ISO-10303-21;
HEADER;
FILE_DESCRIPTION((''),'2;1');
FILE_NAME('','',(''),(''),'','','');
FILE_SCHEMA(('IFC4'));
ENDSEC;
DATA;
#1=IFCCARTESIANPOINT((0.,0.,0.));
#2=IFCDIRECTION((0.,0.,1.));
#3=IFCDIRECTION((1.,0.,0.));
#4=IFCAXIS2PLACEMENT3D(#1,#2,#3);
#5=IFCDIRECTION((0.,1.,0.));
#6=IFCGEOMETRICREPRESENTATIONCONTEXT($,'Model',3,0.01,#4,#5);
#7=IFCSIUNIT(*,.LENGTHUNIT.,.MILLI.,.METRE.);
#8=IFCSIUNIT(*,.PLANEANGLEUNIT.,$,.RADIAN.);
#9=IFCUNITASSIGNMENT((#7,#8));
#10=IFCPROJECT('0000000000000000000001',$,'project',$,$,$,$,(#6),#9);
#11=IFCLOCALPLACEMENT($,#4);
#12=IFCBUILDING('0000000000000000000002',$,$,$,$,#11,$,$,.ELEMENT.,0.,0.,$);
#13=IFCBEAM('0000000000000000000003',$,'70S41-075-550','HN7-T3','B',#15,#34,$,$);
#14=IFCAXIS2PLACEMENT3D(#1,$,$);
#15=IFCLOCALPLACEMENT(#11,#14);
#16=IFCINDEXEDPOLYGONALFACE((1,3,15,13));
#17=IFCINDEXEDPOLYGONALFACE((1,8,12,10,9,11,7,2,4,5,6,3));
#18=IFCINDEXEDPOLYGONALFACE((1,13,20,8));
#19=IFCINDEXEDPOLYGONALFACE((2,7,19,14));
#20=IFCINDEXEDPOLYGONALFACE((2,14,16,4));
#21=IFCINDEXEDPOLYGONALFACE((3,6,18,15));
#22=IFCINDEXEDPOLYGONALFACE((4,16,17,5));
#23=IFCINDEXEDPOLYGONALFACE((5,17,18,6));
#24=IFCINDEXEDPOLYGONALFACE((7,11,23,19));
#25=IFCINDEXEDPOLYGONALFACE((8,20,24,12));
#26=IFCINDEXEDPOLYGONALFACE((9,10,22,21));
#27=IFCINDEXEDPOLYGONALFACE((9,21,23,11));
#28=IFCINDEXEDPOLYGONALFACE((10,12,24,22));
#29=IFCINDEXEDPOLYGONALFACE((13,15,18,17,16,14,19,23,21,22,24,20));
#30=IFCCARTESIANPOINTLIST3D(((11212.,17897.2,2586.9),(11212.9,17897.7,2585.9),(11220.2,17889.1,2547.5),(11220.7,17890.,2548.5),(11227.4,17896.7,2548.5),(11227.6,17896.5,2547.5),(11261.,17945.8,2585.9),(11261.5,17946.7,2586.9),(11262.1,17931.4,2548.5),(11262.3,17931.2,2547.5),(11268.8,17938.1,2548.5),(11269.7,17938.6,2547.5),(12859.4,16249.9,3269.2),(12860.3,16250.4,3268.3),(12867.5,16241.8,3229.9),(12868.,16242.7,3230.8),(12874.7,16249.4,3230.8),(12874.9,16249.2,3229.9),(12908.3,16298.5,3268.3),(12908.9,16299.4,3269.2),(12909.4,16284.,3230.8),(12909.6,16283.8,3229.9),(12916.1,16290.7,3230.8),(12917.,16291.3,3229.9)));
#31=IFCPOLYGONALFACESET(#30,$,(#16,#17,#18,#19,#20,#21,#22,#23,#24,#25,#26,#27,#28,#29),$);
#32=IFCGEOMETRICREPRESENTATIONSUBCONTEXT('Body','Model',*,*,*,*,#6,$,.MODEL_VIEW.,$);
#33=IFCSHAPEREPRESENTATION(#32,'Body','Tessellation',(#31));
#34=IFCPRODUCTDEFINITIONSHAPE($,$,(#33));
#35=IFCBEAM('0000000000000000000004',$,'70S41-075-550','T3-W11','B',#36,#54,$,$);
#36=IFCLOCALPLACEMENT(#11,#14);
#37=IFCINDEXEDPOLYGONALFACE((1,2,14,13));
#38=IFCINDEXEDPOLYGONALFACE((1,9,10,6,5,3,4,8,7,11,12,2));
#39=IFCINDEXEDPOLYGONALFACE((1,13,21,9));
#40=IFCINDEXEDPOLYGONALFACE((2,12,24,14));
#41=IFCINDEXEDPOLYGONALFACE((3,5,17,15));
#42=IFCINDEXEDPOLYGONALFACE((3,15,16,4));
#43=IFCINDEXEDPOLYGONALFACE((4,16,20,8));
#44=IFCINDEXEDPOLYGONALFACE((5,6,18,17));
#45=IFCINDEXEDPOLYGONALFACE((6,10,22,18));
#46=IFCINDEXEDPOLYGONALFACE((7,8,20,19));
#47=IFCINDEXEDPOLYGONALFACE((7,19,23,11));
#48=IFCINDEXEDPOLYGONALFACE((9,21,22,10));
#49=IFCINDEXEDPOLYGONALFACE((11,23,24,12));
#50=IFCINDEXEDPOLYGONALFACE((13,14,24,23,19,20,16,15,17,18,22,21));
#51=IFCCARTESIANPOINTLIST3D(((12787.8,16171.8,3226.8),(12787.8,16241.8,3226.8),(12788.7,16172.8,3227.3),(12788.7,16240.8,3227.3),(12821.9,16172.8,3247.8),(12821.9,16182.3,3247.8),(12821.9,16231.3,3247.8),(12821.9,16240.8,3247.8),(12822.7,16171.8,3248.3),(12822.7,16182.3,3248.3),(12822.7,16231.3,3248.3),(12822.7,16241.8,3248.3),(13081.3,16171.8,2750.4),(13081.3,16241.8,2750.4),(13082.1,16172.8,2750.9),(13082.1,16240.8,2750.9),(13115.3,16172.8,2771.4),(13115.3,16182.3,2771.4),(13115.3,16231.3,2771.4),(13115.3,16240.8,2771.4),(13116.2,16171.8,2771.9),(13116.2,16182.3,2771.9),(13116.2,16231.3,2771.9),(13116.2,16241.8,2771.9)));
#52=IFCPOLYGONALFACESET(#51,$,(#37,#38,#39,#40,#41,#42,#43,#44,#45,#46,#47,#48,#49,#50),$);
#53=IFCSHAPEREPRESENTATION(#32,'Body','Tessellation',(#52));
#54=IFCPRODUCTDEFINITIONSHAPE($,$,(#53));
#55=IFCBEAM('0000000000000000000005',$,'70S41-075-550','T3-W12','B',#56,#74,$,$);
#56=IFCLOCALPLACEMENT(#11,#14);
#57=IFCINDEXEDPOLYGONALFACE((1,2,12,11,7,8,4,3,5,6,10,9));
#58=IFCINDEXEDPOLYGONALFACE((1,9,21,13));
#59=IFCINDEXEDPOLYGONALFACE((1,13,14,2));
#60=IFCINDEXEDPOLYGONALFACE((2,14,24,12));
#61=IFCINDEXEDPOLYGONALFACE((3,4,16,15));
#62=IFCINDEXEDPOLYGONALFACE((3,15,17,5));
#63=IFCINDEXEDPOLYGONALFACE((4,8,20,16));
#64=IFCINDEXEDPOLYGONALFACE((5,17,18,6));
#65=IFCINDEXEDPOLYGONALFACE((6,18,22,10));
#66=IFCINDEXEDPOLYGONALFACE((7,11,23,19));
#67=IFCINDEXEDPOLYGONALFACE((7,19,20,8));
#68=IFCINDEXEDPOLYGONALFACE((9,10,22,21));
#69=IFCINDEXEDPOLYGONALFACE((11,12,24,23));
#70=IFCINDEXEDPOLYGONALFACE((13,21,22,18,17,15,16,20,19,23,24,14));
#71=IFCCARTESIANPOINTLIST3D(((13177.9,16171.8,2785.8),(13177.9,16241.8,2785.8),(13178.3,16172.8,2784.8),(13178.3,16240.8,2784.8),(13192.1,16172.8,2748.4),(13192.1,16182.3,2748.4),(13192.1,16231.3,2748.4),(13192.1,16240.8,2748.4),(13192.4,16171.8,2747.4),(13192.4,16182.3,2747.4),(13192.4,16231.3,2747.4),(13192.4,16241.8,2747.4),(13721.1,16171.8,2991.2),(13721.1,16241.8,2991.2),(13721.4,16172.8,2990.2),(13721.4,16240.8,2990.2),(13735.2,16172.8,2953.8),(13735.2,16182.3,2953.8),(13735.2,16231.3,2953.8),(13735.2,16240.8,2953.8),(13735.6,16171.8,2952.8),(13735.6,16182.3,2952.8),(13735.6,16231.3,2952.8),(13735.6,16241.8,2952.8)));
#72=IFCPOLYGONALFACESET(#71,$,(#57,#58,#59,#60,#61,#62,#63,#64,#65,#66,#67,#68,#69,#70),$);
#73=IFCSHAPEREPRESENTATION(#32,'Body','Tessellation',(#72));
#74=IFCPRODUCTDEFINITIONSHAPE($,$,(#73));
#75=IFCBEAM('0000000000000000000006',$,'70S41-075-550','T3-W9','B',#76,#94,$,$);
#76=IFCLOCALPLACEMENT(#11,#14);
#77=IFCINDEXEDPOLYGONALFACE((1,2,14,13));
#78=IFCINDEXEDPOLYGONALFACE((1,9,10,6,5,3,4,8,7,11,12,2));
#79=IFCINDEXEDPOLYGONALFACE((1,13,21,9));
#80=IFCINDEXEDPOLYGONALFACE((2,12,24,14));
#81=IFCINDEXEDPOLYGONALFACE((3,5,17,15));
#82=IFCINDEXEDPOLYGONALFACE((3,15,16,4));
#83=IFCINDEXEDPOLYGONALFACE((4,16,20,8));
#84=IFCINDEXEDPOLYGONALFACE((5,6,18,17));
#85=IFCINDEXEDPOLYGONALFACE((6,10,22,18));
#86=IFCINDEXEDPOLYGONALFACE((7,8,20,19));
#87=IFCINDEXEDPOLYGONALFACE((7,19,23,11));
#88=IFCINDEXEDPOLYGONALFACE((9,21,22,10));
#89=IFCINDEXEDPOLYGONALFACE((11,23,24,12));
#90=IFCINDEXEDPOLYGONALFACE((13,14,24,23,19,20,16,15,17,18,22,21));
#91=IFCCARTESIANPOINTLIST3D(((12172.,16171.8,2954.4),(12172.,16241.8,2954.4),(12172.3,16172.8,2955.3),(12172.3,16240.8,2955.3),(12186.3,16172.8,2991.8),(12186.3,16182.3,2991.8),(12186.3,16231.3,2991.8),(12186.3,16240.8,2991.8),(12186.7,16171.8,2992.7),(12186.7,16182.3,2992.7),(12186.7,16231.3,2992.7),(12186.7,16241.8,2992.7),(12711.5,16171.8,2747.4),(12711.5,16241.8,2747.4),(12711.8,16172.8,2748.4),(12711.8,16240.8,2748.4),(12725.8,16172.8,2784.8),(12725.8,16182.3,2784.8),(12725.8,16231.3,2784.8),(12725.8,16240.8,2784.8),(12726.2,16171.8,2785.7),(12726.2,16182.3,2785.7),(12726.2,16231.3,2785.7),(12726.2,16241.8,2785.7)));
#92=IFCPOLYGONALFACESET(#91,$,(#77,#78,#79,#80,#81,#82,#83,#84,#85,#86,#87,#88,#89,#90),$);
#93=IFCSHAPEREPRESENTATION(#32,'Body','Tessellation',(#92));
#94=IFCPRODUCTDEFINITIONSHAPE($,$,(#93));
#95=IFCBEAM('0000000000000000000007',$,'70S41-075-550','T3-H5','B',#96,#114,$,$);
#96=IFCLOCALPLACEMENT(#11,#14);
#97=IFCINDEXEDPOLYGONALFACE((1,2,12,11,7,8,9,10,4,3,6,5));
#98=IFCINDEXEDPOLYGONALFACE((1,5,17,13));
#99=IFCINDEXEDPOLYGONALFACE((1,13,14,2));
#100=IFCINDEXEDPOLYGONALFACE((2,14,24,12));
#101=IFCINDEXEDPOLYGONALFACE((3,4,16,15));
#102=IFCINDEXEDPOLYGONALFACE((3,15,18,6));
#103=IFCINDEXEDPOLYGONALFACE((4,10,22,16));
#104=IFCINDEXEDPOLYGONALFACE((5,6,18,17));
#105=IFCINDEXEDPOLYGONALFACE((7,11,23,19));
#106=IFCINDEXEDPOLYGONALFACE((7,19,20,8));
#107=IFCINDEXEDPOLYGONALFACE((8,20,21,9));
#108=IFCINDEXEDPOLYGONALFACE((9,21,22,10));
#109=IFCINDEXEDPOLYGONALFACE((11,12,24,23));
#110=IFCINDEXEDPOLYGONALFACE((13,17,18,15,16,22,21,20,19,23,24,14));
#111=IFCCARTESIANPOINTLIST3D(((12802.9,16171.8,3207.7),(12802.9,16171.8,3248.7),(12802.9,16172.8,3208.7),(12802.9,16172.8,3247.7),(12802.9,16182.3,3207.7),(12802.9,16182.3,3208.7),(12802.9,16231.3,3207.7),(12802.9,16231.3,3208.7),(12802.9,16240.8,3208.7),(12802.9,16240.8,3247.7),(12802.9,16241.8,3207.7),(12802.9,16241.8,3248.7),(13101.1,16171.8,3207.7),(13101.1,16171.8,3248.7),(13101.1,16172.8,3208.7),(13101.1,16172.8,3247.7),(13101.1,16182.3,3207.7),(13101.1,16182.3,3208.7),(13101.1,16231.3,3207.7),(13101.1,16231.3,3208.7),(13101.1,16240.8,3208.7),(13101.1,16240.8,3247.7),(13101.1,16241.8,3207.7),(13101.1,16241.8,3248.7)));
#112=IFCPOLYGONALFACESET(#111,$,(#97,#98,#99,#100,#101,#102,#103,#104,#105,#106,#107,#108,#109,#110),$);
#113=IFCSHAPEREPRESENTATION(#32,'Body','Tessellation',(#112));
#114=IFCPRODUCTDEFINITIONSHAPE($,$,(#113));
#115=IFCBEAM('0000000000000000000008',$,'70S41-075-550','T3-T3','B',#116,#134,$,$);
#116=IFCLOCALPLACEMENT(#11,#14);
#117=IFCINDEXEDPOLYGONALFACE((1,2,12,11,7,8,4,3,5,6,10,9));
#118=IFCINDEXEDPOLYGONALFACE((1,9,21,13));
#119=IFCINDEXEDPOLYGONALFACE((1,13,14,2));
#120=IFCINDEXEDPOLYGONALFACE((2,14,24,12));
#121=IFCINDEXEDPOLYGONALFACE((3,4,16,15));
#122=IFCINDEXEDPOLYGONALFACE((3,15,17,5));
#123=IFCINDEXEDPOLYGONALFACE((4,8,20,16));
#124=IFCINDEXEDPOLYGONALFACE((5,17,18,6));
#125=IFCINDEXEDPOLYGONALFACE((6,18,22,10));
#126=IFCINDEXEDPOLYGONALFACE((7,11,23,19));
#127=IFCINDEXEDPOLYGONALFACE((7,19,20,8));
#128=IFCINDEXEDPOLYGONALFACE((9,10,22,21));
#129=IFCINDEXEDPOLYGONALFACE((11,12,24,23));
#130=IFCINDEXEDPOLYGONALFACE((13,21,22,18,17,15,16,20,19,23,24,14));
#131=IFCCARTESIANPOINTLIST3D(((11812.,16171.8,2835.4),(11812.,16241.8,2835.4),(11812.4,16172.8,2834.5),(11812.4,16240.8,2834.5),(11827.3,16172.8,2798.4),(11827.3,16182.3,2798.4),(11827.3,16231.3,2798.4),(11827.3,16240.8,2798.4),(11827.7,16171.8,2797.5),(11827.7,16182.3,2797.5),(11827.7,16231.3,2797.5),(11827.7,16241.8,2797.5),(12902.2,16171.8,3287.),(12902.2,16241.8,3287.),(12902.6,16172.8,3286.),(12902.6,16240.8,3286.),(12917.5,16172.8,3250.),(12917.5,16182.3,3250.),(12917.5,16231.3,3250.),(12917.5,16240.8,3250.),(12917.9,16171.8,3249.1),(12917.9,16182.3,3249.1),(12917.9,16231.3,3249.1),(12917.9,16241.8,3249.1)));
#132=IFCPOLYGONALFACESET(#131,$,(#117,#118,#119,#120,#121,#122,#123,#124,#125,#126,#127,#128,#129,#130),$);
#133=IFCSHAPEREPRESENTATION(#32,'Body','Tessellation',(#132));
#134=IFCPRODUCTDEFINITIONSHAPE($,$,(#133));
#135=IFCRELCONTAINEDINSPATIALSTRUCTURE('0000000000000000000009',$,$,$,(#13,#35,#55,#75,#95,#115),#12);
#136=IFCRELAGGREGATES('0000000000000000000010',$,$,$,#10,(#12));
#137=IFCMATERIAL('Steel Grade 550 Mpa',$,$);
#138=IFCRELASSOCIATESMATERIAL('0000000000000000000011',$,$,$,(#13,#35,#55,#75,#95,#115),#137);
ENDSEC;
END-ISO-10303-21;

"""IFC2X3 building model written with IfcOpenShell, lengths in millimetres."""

from ifc_helpers import new_model, si_unit, direction, frame, origin, origin_with_axes, origin_2d_with_axis, place, context, subcontext, project, spatial, c_section, extrude, source, transform, mapped, material, element, save


model = new_model("IFC2X3")

# Units and contexts
model_context = context("Model", 3, precision=0.01, world=origin_with_axes(), true_north=direction((0.0, 1.0, 0.0)))
body_context = subcontext(model_context, "Body", "Model", "MODEL_VIEW")
ifc_project = project(units=[si_unit("LENGTHUNIT", "METRE", prefix="MILLI"), si_unit("PLANEANGLEUNIT", "RADIAN")], contexts=[model_context])

# Building
building_placement = place(None, origin_with_axes())
building = spatial("IfcBuilding", under=ifc_project, at=building_placement, CompositionType="ELEMENT", ElevationOfRefHeight=0.0, ElevationOfTerrain=0.0)

# Shared definitions
ifc_material = material(Name="Steel Grade 550 Mpa")

# Beams
shared_shape_1 = source(origin(), body_context, "Body", "SweptSolid", [
    extrude(c_section(Depth=70.0, Width=41.0, WallThickness=1.0, Girth=10.5, at=origin_2d_with_axis()), origin_with_axes(), (0.0, 0.0, 1.0), 2427.5),
])
beam_1_placement = place(None, frame((12888.2, 16270.6, 3249.6), z_axis=(-0.678598, 0.678598, -0.281085), x_axis=(0.198757, -0.198757, -0.959683)))
element("IfcBeam", 1, at=beam_1_placement, inside=building, material=ifc_material, Name="70S41-075-550", Description="HN7-T3", ObjectType="B", context=body_context, shape_type="MappedRepresentation", body=[
    mapped(shared_shape_1, transform((0.0, 0.0, 0.0), scale=1.0)),
])
shared_shape_2 = source(origin(), body_context, "Body", "SweptSolid", [
    extrude(c_section(Depth=70.0, Width=41.0, WallThickness=1.0, Girth=10.5, at=origin_2d_with_axis()), origin_with_axes(), (0.0, 0.0, 1.0), 559.6),
])
beam_2_placement = place(None, frame((12805.3, 16206.8, 3237.6), z_axis=(0.524434, 0.0, -0.851451), x_axis=(0.851451, 0.0, 0.524434)))
element("IfcBeam", 2, at=beam_2_placement, inside=building, material=ifc_material, Name="70S41-075-550", Description="T3-W11", ObjectType="B", context=body_context, shape_type="MappedRepresentation", body=[
    mapped(shared_shape_2, transform((0.0, 0.0, 0.0), scale=1.0)),
])
shared_shape_3 = source(origin(), body_context, "Body", "SweptSolid", [
    extrude(c_section(Depth=70.0, Width=41.0, WallThickness=1.0, Girth=10.5, at=origin_2d_with_axis()), origin_with_axes(), (0.0, 0.0, 1.0), 580.7),
])
beam_3_placement = place(None, frame((13728.3, 16206.8, 2972.0), z_axis=(-0.935357, 0.0, -0.353704), x_axis=(0.353704, 0.0, -0.935357)))
element("IfcBeam", 3, at=beam_3_placement, inside=building, material=ifc_material, Name="70S41-075-550", Description="T3-W12", ObjectType="B", context=body_context, shape_type="MappedRepresentation", body=[
    mapped(shared_shape_3, transform((0.0, 0.0, 0.0), scale=1.0)),
])
shared_shape_4 = source(origin(), body_context, "Body", "SweptSolid", [
    extrude(c_section(Depth=70.0, Width=41.0, WallThickness=1.0, Girth=10.5, at=origin_2d_with_axis()), origin_with_axes(), (0.0, 0.0, 1.0), 577.9),
])
beam_4_placement = place(None, frame((12179.3, 16206.8, 2973.5), z_axis=(0.933643, 0.0, -0.358204), x_axis=(0.358204, 0.0, 0.933643)))
element("IfcBeam", 4, at=beam_4_placement, inside=building, material=ifc_material, Name="70S41-075-550", Description="T3-W9", ObjectType="B", context=body_context, shape_type="MappedRepresentation", body=[
    mapped(shared_shape_4, transform((0.0, 0.0, 0.0), scale=1.0)),
])
shared_shape_5 = source(origin(), body_context, "Body", "SweptSolid", [
    extrude(c_section(Depth=70.0, Width=41.0, WallThickness=1.0, Girth=10.5, at=origin_2d_with_axis()), origin_with_axes(), (0.0, 0.0, 1.0), 298.3),
])
beam_5_placement = place(None, frame((13101.1, 16206.8, 3228.2), z_axis=(-1.0, 0.0, 0.0), x_axis=(0.0, 0.0, -1.0)))
element("IfcBeam", 5, at=beam_5_placement, inside=building, material=ifc_material, Name="70S41-075-550", Description="T3-H5", ObjectType="B", context=body_context, shape_type="MappedRepresentation", body=[
    mapped(shared_shape_5, transform((0.0, 0.0, 0.0), scale=1.0)),
])
shared_shape_6 = source(origin(), body_context, "Body", "SweptSolid", [
    extrude(c_section(Depth=70.0, Width=41.0, WallThickness=1.0, Girth=10.5, at=origin_2d_with_axis()), origin_with_axes(), (0.0, 0.0, 1.0), 1180.0),
])
beam_6_placement = place(None, frame((12910.0, 16206.8, 3268.0), z_axis=(-0.92388, 0.0, -0.382683), x_axis=(0.382683, 0.0, -0.92388)))
element("IfcBeam", 6, at=beam_6_placement, inside=building, material=ifc_material, Name="70S41-075-550", Description="T3-T3", ObjectType="B", context=body_context, shape_type="MappedRepresentation", body=[
    mapped(shared_shape_6, transform((0.0, 0.0, 0.0), scale=1.0)),
])

save(model, "model.ifc")
